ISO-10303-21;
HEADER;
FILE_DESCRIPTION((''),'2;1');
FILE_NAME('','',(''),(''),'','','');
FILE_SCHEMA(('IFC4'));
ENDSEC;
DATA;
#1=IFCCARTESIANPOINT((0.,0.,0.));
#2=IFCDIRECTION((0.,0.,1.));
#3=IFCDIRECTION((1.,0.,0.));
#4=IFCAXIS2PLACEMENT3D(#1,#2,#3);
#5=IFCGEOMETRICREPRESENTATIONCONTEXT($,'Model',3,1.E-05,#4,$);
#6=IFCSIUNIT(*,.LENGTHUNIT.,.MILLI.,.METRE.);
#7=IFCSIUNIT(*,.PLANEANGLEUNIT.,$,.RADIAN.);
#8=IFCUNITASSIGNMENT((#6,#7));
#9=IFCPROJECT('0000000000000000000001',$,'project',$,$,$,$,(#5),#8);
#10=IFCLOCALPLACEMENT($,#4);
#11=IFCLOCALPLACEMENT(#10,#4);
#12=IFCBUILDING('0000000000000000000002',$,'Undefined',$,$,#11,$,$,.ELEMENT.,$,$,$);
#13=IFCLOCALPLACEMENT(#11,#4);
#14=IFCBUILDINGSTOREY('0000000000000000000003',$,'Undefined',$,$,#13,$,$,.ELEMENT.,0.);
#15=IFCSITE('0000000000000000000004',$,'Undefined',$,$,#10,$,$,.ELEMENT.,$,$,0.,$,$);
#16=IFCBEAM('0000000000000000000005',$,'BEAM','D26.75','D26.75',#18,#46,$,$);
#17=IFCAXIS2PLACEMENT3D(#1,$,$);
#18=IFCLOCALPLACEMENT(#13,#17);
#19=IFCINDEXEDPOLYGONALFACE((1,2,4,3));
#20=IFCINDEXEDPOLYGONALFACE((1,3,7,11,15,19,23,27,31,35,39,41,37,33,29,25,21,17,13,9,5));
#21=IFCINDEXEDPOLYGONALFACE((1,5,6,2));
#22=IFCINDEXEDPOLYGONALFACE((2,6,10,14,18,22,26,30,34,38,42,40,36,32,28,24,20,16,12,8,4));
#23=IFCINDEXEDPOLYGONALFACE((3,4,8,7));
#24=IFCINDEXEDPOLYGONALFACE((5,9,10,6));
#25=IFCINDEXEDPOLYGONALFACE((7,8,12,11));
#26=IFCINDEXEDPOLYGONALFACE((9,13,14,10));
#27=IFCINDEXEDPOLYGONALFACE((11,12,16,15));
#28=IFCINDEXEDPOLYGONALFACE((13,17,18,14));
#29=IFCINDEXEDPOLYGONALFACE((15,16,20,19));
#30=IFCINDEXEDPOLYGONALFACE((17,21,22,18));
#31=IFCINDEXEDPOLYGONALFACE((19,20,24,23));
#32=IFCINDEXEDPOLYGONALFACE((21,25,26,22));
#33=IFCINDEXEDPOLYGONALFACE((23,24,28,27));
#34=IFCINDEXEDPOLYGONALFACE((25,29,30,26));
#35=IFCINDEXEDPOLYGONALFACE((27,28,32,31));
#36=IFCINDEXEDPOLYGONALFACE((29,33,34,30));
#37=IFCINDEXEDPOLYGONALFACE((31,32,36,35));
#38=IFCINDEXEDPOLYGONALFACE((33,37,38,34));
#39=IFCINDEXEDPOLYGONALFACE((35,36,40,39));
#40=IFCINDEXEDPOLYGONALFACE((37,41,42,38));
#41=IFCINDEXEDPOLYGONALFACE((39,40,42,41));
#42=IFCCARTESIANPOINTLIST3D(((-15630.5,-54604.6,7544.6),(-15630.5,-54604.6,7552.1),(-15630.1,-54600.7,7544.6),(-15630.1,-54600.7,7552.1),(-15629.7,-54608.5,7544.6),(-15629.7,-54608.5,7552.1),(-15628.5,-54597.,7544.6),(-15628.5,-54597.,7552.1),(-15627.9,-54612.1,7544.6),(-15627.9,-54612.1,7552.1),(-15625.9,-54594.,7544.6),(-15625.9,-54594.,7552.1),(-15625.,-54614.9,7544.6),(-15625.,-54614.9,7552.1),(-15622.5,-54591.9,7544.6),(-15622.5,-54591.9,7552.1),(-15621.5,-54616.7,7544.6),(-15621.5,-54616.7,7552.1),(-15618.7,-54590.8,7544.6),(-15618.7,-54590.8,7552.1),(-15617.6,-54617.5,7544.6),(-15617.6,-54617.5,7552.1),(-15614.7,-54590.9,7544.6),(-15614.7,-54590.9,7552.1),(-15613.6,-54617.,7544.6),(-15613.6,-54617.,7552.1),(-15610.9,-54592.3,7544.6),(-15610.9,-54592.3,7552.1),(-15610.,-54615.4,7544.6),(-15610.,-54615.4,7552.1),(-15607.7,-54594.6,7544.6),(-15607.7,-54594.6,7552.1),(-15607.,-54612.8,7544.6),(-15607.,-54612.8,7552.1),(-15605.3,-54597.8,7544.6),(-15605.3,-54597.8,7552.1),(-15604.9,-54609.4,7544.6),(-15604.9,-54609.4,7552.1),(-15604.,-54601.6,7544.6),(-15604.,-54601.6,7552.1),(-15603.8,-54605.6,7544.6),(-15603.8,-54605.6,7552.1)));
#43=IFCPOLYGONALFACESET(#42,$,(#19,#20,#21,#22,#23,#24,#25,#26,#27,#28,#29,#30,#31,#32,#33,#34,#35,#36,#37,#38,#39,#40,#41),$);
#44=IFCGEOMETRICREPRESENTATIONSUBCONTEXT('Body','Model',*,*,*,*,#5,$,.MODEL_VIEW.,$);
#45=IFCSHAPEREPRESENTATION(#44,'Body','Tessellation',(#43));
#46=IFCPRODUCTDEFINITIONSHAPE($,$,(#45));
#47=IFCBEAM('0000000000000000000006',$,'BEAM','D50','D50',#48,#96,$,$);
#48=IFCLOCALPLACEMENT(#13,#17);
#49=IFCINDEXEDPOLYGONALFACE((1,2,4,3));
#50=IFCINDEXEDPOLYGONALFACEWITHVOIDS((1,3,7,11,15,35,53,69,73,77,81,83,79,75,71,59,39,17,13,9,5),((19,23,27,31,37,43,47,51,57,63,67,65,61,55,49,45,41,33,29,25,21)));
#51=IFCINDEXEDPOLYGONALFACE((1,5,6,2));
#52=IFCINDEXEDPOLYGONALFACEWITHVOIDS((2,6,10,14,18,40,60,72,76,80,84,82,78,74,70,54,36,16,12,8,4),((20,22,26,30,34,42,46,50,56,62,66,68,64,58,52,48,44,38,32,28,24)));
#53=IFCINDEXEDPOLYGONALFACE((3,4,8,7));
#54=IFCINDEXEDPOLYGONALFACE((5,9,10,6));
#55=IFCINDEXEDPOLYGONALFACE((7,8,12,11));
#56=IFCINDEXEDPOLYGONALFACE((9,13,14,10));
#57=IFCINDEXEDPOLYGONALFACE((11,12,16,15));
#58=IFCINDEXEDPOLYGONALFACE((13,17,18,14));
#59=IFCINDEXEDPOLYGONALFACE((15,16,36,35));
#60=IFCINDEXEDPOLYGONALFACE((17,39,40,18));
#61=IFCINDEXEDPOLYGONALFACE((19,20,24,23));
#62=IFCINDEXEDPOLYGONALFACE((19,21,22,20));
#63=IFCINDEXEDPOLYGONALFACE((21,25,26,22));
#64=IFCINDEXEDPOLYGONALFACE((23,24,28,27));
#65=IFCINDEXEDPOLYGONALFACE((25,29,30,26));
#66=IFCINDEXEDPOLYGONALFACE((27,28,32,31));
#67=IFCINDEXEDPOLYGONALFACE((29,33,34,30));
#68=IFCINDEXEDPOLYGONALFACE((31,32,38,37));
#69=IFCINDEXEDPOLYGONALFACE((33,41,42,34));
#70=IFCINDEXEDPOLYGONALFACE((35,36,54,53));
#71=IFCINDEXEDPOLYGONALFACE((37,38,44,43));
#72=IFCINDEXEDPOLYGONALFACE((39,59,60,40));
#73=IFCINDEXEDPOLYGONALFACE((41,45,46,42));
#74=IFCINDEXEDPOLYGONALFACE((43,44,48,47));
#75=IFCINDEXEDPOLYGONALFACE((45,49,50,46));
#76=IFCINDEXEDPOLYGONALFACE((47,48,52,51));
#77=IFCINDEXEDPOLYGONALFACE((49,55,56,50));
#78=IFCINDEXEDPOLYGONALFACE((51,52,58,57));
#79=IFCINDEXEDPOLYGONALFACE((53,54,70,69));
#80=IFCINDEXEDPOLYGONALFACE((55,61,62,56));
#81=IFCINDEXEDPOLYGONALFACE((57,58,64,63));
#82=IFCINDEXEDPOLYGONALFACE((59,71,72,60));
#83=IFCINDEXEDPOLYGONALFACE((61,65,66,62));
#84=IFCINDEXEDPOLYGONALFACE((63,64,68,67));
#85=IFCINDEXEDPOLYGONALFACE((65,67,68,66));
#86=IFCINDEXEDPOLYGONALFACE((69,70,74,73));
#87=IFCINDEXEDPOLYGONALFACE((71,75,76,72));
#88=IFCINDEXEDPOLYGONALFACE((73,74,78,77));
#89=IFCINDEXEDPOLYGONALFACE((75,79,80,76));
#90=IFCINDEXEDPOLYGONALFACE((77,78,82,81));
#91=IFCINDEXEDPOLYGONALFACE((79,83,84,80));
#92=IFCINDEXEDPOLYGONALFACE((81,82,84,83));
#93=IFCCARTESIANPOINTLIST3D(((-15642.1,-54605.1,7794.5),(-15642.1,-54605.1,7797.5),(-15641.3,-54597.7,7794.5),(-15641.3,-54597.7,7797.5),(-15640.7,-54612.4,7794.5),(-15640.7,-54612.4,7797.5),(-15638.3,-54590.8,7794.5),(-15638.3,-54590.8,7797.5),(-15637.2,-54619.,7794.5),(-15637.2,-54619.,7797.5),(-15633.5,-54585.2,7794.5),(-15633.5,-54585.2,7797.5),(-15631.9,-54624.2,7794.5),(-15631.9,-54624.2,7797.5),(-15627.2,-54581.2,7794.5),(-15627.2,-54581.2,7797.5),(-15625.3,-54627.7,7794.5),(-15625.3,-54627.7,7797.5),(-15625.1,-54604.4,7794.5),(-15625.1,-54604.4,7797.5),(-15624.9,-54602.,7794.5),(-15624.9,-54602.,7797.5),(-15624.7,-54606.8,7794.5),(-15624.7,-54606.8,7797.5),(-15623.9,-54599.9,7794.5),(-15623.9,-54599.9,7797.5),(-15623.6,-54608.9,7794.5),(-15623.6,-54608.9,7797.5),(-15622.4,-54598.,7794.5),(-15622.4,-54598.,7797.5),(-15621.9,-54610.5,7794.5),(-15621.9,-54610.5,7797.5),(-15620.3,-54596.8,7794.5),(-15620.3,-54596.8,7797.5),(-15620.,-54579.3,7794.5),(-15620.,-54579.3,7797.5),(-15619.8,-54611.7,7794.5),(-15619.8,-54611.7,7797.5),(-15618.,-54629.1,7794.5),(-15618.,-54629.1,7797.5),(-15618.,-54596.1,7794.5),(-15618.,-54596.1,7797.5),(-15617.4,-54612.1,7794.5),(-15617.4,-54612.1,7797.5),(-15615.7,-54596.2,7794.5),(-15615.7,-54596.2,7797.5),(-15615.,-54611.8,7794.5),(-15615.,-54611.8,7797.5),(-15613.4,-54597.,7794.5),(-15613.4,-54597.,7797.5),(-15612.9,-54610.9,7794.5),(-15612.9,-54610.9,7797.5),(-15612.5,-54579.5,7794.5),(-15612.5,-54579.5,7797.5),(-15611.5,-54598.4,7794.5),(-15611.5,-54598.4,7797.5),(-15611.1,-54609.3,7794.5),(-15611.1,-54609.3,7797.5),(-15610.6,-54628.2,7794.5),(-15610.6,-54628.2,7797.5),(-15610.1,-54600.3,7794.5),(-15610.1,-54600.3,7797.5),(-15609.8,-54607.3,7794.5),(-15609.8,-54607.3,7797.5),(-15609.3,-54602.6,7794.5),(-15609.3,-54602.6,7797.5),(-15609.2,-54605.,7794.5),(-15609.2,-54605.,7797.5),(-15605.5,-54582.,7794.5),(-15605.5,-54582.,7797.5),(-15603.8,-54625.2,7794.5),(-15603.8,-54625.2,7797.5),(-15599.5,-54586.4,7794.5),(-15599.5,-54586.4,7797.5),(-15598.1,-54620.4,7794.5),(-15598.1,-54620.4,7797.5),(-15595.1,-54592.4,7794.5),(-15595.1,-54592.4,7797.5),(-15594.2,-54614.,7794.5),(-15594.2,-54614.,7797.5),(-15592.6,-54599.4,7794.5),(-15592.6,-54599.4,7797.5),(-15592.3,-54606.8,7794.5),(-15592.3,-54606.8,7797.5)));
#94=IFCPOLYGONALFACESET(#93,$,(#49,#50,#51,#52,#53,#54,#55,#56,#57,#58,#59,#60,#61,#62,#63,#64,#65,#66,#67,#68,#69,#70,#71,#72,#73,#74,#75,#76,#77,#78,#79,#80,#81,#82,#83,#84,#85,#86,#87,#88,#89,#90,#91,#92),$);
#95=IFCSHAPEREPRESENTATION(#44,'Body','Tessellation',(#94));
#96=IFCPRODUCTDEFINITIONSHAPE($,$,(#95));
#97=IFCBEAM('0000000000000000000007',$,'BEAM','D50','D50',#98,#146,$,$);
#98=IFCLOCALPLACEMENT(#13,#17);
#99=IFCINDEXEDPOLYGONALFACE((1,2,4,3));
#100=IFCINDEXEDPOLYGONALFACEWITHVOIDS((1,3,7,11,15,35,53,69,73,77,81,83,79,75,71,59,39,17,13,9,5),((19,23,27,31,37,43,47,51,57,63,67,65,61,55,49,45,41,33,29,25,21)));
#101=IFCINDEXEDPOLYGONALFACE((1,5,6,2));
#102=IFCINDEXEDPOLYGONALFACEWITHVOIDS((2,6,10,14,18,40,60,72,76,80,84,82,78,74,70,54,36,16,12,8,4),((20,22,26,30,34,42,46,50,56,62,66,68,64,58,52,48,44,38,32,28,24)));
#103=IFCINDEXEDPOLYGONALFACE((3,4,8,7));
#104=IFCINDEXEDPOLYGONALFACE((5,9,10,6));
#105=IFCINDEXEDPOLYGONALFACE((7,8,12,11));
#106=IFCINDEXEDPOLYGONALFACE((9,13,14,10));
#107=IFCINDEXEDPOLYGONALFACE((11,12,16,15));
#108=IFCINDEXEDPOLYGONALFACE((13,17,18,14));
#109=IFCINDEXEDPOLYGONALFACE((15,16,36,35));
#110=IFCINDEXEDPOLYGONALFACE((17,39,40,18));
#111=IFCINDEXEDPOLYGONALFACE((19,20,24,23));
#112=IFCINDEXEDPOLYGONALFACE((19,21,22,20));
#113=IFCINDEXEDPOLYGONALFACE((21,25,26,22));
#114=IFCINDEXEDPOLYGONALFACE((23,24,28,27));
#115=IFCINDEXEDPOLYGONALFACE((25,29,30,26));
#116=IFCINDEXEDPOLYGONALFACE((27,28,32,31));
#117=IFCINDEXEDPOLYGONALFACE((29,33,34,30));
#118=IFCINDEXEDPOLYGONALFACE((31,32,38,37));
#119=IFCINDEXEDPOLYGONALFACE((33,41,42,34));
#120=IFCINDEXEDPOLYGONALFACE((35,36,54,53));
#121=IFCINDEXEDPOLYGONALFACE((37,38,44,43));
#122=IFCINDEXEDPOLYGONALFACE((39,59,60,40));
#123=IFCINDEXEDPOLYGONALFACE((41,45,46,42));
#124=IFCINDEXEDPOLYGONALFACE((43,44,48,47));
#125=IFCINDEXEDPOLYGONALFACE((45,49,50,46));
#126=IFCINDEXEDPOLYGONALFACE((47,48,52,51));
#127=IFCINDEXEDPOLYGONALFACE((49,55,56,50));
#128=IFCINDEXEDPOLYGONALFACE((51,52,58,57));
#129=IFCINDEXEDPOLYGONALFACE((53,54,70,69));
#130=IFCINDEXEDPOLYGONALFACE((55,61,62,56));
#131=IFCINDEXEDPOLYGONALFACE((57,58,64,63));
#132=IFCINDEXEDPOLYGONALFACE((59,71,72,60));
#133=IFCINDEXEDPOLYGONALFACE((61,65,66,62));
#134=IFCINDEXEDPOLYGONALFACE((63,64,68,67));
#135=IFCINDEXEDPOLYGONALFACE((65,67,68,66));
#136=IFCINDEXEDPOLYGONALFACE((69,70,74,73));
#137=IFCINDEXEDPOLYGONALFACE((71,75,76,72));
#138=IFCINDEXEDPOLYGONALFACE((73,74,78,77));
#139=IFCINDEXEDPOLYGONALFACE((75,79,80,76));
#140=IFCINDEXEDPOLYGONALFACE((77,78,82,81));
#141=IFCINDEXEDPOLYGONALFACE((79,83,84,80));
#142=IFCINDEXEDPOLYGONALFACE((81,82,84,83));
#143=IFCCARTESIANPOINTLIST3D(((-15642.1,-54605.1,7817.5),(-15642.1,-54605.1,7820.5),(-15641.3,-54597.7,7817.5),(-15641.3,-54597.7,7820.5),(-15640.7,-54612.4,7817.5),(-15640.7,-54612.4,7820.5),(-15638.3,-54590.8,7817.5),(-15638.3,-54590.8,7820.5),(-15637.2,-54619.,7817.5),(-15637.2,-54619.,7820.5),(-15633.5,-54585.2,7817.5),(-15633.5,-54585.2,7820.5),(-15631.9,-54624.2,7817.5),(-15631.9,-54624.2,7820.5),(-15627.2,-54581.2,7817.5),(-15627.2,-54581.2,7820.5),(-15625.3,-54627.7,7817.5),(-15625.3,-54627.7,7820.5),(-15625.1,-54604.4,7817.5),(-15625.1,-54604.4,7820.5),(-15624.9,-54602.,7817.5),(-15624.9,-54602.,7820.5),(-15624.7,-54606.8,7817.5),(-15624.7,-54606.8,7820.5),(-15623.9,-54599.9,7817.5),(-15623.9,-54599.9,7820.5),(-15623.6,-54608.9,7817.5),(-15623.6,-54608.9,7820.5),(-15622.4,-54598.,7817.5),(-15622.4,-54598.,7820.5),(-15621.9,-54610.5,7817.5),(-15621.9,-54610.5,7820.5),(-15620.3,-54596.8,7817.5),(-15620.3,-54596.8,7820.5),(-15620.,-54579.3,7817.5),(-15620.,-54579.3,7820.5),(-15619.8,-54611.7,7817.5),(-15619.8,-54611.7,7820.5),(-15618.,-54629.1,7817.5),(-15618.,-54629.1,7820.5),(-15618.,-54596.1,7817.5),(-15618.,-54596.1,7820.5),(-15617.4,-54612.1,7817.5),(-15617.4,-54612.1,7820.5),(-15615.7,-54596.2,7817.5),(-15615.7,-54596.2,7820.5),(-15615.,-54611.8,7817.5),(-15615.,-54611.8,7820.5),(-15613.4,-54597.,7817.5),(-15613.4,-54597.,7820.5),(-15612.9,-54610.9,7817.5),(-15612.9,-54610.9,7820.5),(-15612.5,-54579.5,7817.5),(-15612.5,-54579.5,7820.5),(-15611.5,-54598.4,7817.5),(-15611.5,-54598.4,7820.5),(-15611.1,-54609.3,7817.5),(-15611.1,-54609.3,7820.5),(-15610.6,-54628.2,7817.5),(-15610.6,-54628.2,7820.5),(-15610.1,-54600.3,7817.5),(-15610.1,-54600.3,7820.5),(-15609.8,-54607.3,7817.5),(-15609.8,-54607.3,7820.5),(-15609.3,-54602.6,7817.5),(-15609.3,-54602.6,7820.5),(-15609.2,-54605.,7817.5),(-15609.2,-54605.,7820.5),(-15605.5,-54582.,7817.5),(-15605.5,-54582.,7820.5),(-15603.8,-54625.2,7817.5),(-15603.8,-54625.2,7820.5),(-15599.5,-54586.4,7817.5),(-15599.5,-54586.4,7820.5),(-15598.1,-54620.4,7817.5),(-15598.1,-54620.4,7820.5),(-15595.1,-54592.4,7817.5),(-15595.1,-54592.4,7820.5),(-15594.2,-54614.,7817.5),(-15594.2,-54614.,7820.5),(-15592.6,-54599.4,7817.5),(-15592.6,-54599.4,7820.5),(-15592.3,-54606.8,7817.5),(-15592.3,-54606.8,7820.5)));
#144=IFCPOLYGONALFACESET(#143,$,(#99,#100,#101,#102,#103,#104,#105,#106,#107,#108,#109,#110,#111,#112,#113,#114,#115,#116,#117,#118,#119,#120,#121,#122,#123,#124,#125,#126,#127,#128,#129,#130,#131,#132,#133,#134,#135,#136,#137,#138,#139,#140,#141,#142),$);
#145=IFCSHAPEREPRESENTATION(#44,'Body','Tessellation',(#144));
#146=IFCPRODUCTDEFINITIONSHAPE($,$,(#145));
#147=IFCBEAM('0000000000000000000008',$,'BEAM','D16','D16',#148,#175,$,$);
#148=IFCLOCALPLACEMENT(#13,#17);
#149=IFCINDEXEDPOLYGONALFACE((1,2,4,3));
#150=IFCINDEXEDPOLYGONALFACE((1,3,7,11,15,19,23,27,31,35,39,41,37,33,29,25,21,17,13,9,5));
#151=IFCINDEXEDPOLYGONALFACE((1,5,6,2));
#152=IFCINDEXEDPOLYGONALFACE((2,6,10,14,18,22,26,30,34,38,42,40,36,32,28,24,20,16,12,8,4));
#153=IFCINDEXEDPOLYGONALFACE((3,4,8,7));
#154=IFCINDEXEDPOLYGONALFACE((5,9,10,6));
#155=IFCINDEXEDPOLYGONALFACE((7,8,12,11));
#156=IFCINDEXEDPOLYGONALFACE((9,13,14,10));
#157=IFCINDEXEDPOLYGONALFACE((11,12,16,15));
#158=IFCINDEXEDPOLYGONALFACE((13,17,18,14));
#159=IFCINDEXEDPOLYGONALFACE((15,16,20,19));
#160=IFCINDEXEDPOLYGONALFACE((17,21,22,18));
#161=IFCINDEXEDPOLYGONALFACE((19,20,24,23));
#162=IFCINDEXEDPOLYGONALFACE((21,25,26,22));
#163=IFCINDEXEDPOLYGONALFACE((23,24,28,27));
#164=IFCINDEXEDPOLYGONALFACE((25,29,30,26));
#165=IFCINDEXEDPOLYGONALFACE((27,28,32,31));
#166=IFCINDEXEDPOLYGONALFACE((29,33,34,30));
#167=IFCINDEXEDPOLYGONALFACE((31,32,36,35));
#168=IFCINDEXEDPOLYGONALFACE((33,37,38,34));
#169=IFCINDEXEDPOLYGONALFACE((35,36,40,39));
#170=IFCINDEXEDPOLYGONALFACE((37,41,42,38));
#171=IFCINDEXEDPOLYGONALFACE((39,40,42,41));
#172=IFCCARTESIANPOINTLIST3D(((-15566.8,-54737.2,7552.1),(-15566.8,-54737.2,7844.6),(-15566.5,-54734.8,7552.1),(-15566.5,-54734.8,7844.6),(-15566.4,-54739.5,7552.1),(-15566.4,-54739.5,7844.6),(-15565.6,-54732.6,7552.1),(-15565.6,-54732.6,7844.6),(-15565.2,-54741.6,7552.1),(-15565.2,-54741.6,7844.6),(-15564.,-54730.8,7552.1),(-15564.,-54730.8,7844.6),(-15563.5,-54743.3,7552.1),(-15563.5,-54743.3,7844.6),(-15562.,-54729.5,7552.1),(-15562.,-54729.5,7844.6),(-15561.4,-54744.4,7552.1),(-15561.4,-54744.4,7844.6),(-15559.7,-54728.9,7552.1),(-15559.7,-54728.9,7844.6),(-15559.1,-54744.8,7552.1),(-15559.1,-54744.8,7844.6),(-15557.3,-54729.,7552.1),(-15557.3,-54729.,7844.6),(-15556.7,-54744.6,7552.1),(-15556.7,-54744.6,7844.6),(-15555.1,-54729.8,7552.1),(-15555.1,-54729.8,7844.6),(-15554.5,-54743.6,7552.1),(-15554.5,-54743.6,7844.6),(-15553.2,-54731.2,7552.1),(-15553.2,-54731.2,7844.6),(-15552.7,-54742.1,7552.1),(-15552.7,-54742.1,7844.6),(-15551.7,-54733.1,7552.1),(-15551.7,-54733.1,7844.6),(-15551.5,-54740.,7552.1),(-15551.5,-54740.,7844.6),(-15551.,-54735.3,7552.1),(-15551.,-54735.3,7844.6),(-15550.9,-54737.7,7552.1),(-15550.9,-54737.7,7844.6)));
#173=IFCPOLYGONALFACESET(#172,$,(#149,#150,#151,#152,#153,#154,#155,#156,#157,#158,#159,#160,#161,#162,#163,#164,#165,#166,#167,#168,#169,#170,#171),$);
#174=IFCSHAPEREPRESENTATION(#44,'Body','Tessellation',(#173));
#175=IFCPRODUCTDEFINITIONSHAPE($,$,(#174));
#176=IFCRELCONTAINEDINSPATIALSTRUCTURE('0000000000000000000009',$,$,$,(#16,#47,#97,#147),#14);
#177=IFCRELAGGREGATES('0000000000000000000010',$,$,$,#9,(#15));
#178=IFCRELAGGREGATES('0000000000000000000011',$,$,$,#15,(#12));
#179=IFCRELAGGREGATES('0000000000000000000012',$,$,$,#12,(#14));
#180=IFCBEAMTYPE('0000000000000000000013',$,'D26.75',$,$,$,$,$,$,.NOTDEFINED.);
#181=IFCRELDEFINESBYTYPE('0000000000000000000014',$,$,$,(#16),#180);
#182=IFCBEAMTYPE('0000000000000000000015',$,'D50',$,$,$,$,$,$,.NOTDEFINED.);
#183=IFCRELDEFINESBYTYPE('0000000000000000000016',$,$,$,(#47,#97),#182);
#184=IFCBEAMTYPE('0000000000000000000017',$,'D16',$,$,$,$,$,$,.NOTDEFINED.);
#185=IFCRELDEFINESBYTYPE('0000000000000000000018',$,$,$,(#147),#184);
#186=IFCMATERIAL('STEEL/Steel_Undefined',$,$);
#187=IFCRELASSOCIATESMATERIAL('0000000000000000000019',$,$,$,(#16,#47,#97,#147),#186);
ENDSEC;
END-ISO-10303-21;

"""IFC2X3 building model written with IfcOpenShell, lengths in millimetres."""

from ifc_helpers import new_model, si_unit, frame, origin_with_axes, origin_2d_with_axis, place, context, subcontext, project, spatial, circle, extrude, material, type_object, element, save


model = new_model("IFC2X3")

# Units and contexts
model_context = context("Model", 3, precision=1e-05, world=origin_with_axes())
body_context = subcontext(model_context, "Body", "Model", "MODEL_VIEW")
ifc_project = project(units=[si_unit("LENGTHUNIT", "METRE", prefix="MILLI"), si_unit("PLANEANGLEUNIT", "RADIAN")], contexts=[model_context])

# Site, building, storey
site_placement = place(None, origin_with_axes())
site = spatial("IfcSite", under=ifc_project, at=site_placement, Name="Undefined", CompositionType="ELEMENT", RefElevation=0.0)
building_placement = place(site_placement, origin_with_axes())
building = spatial("IfcBuilding", under=site, at=building_placement, Name="Undefined", CompositionType="ELEMENT")
storey_placement = place(building_placement, origin_with_axes())
storey = spatial("IfcBuildingStorey", under=building, at=storey_placement, Name="Undefined", CompositionType="ELEMENT", Elevation=0.0)

# Shared definitions
ifc_material_1 = material(Name="STEEL/Steel_Undefined")
beam_type_1 = type_object("IfcBeamType", Name="D26.75", PredefinedType="NOTDEFINED")

# Beam
beam_1_placement = place(storey_placement, frame((-15617.1, -54604.1, 7552.1), z_axis=(-0.915553, -0.402197, 0.0), x_axis=(0.0, 0.0, -1.0)))
element("IfcBeam", 1, at=beam_1_placement, inside=storey, type_object=beam_type_1, material=ifc_material_1, Name="BEAM", Description="D26.75", ObjectType="D26.75", context=body_context, shape_type="SweptSolid", body=[
    extrude(circle(Radius=13.4, at=origin_2d_with_axis()), frame((7.4, 0.0, 0.0), z_axis=(-1.0, 0.0, 0.0), x_axis=(0.0, -1.0, 0.0)), (0.0, 0.0, 1.0), 7.4),
])

# Beams, openings
beam_type_2 = type_object("IfcBeamType", Name="D50", PredefinedType="NOTDEFINED")
beam_2_placement = place(storey_placement, frame((-15617.1, -54604.1, 7797.5), z_axis=(-0.915553, -0.402197, 0.0), x_axis=(0.0, 0.0, -1.0)))
beam_2 = element("IfcBeam", 2, at=beam_2_placement, inside=storey, type_object=beam_type_2, material=ifc_material_1, Name="BEAM", Description="D50", ObjectType="D50", context=body_context, shape_type="SweptSolid", body=[
    extrude(circle(Radius=25.0, at=origin_2d_with_axis()), frame((3.0, 0.0, 0.0), z_axis=(-1.0, 0.0, 0.0), x_axis=(0.0, -1.0, 0.0)), (0.0, 0.0, 1.0), 3.0),
])
opening_1_placement = place(storey_placement, frame((-15617.1, -54604.1, 7797.5), z_axis=(-0.915553, -0.402197, 0.0), x_axis=(0.0, 0.0, -1.0)))
element("IfcOpeningElement", 3, at=opening_1_placement, cuts=beam_2, ObjectType="Recess", context=body_context, shape_type="SweptSolid", body=[
    extrude(circle(Radius=8.0, at=origin_2d_with_axis()), frame((245.5, 0.0, 0.0), z_axis=(-1.0, 0.0, 0.0), x_axis=(0.0, -1.0, 0.0)), (0.0, 0.0, 1.0), 292.6),
])
beam_3_placement = place(storey_placement, frame((-15617.1, -54604.1, 7820.5), z_axis=(-0.915553, -0.402197, 0.0), x_axis=(0.0, 0.0, -1.0)))
beam_3 = element("IfcBeam", 4, at=beam_3_placement, inside=storey, type_object=beam_type_2, material=ifc_material_1, Name="BEAM", Description="D50", ObjectType="D50", context=body_context, shape_type="SweptSolid", body=[
    extrude(circle(Radius=25.0, at=origin_2d_with_axis()), frame((3.0, 0.0, 0.0), z_axis=(-1.0, 0.0, 0.0), x_axis=(0.0, -1.0, 0.0)), (0.0, 0.0, 1.0), 3.0),
])
opening_2_placement = place(storey_placement, frame((-15617.1, -54604.1, 7820.5), z_axis=(-0.915553, -0.402197, 0.0), x_axis=(0.0, 0.0, -1.0)))
element("IfcOpeningElement", 5, at=opening_2_placement, cuts=beam_3, ObjectType="Recess", context=body_context, shape_type="SweptSolid", body=[
    extrude(circle(Radius=8.0, at=origin_2d_with_axis()), frame((268.5, 0.0, 0.0), z_axis=(-1.0, 0.0, 0.0), x_axis=(0.0, -1.0, 0.0)), (0.0, 0.0, 1.0), 292.6),
])

# Beam
beam_type_3 = type_object("IfcBeamType", Name="D16", PredefinedType="NOTDEFINED")
for number, where, z_axis, x_axis, name in (
    (6, (-15558.8, -54736.9, 7844.6), (-0.915553, -0.402197, 0.0), (0.0, 0.0, -1.0), "BEAM"),
):
    element("IfcBeam", number, at=place(storey_placement, frame(where, z_axis=z_axis, x_axis=x_axis)), inside=storey, type_object=beam_type_3, material=ifc_material_1, Name=name, Description="D16", ObjectType="D16", context=body_context, shape_type="SweptSolid", body=[
        extrude(circle(Radius=8.0, at=origin_2d_with_axis()), frame((292.6, 0.0, 0.0), z_axis=(-1.0, 0.0, 0.0), x_axis=(0.0, -1.0, 0.0)), (0.0, 0.0, 1.0), 292.6),
    ])

save(model, "model.ifc")
